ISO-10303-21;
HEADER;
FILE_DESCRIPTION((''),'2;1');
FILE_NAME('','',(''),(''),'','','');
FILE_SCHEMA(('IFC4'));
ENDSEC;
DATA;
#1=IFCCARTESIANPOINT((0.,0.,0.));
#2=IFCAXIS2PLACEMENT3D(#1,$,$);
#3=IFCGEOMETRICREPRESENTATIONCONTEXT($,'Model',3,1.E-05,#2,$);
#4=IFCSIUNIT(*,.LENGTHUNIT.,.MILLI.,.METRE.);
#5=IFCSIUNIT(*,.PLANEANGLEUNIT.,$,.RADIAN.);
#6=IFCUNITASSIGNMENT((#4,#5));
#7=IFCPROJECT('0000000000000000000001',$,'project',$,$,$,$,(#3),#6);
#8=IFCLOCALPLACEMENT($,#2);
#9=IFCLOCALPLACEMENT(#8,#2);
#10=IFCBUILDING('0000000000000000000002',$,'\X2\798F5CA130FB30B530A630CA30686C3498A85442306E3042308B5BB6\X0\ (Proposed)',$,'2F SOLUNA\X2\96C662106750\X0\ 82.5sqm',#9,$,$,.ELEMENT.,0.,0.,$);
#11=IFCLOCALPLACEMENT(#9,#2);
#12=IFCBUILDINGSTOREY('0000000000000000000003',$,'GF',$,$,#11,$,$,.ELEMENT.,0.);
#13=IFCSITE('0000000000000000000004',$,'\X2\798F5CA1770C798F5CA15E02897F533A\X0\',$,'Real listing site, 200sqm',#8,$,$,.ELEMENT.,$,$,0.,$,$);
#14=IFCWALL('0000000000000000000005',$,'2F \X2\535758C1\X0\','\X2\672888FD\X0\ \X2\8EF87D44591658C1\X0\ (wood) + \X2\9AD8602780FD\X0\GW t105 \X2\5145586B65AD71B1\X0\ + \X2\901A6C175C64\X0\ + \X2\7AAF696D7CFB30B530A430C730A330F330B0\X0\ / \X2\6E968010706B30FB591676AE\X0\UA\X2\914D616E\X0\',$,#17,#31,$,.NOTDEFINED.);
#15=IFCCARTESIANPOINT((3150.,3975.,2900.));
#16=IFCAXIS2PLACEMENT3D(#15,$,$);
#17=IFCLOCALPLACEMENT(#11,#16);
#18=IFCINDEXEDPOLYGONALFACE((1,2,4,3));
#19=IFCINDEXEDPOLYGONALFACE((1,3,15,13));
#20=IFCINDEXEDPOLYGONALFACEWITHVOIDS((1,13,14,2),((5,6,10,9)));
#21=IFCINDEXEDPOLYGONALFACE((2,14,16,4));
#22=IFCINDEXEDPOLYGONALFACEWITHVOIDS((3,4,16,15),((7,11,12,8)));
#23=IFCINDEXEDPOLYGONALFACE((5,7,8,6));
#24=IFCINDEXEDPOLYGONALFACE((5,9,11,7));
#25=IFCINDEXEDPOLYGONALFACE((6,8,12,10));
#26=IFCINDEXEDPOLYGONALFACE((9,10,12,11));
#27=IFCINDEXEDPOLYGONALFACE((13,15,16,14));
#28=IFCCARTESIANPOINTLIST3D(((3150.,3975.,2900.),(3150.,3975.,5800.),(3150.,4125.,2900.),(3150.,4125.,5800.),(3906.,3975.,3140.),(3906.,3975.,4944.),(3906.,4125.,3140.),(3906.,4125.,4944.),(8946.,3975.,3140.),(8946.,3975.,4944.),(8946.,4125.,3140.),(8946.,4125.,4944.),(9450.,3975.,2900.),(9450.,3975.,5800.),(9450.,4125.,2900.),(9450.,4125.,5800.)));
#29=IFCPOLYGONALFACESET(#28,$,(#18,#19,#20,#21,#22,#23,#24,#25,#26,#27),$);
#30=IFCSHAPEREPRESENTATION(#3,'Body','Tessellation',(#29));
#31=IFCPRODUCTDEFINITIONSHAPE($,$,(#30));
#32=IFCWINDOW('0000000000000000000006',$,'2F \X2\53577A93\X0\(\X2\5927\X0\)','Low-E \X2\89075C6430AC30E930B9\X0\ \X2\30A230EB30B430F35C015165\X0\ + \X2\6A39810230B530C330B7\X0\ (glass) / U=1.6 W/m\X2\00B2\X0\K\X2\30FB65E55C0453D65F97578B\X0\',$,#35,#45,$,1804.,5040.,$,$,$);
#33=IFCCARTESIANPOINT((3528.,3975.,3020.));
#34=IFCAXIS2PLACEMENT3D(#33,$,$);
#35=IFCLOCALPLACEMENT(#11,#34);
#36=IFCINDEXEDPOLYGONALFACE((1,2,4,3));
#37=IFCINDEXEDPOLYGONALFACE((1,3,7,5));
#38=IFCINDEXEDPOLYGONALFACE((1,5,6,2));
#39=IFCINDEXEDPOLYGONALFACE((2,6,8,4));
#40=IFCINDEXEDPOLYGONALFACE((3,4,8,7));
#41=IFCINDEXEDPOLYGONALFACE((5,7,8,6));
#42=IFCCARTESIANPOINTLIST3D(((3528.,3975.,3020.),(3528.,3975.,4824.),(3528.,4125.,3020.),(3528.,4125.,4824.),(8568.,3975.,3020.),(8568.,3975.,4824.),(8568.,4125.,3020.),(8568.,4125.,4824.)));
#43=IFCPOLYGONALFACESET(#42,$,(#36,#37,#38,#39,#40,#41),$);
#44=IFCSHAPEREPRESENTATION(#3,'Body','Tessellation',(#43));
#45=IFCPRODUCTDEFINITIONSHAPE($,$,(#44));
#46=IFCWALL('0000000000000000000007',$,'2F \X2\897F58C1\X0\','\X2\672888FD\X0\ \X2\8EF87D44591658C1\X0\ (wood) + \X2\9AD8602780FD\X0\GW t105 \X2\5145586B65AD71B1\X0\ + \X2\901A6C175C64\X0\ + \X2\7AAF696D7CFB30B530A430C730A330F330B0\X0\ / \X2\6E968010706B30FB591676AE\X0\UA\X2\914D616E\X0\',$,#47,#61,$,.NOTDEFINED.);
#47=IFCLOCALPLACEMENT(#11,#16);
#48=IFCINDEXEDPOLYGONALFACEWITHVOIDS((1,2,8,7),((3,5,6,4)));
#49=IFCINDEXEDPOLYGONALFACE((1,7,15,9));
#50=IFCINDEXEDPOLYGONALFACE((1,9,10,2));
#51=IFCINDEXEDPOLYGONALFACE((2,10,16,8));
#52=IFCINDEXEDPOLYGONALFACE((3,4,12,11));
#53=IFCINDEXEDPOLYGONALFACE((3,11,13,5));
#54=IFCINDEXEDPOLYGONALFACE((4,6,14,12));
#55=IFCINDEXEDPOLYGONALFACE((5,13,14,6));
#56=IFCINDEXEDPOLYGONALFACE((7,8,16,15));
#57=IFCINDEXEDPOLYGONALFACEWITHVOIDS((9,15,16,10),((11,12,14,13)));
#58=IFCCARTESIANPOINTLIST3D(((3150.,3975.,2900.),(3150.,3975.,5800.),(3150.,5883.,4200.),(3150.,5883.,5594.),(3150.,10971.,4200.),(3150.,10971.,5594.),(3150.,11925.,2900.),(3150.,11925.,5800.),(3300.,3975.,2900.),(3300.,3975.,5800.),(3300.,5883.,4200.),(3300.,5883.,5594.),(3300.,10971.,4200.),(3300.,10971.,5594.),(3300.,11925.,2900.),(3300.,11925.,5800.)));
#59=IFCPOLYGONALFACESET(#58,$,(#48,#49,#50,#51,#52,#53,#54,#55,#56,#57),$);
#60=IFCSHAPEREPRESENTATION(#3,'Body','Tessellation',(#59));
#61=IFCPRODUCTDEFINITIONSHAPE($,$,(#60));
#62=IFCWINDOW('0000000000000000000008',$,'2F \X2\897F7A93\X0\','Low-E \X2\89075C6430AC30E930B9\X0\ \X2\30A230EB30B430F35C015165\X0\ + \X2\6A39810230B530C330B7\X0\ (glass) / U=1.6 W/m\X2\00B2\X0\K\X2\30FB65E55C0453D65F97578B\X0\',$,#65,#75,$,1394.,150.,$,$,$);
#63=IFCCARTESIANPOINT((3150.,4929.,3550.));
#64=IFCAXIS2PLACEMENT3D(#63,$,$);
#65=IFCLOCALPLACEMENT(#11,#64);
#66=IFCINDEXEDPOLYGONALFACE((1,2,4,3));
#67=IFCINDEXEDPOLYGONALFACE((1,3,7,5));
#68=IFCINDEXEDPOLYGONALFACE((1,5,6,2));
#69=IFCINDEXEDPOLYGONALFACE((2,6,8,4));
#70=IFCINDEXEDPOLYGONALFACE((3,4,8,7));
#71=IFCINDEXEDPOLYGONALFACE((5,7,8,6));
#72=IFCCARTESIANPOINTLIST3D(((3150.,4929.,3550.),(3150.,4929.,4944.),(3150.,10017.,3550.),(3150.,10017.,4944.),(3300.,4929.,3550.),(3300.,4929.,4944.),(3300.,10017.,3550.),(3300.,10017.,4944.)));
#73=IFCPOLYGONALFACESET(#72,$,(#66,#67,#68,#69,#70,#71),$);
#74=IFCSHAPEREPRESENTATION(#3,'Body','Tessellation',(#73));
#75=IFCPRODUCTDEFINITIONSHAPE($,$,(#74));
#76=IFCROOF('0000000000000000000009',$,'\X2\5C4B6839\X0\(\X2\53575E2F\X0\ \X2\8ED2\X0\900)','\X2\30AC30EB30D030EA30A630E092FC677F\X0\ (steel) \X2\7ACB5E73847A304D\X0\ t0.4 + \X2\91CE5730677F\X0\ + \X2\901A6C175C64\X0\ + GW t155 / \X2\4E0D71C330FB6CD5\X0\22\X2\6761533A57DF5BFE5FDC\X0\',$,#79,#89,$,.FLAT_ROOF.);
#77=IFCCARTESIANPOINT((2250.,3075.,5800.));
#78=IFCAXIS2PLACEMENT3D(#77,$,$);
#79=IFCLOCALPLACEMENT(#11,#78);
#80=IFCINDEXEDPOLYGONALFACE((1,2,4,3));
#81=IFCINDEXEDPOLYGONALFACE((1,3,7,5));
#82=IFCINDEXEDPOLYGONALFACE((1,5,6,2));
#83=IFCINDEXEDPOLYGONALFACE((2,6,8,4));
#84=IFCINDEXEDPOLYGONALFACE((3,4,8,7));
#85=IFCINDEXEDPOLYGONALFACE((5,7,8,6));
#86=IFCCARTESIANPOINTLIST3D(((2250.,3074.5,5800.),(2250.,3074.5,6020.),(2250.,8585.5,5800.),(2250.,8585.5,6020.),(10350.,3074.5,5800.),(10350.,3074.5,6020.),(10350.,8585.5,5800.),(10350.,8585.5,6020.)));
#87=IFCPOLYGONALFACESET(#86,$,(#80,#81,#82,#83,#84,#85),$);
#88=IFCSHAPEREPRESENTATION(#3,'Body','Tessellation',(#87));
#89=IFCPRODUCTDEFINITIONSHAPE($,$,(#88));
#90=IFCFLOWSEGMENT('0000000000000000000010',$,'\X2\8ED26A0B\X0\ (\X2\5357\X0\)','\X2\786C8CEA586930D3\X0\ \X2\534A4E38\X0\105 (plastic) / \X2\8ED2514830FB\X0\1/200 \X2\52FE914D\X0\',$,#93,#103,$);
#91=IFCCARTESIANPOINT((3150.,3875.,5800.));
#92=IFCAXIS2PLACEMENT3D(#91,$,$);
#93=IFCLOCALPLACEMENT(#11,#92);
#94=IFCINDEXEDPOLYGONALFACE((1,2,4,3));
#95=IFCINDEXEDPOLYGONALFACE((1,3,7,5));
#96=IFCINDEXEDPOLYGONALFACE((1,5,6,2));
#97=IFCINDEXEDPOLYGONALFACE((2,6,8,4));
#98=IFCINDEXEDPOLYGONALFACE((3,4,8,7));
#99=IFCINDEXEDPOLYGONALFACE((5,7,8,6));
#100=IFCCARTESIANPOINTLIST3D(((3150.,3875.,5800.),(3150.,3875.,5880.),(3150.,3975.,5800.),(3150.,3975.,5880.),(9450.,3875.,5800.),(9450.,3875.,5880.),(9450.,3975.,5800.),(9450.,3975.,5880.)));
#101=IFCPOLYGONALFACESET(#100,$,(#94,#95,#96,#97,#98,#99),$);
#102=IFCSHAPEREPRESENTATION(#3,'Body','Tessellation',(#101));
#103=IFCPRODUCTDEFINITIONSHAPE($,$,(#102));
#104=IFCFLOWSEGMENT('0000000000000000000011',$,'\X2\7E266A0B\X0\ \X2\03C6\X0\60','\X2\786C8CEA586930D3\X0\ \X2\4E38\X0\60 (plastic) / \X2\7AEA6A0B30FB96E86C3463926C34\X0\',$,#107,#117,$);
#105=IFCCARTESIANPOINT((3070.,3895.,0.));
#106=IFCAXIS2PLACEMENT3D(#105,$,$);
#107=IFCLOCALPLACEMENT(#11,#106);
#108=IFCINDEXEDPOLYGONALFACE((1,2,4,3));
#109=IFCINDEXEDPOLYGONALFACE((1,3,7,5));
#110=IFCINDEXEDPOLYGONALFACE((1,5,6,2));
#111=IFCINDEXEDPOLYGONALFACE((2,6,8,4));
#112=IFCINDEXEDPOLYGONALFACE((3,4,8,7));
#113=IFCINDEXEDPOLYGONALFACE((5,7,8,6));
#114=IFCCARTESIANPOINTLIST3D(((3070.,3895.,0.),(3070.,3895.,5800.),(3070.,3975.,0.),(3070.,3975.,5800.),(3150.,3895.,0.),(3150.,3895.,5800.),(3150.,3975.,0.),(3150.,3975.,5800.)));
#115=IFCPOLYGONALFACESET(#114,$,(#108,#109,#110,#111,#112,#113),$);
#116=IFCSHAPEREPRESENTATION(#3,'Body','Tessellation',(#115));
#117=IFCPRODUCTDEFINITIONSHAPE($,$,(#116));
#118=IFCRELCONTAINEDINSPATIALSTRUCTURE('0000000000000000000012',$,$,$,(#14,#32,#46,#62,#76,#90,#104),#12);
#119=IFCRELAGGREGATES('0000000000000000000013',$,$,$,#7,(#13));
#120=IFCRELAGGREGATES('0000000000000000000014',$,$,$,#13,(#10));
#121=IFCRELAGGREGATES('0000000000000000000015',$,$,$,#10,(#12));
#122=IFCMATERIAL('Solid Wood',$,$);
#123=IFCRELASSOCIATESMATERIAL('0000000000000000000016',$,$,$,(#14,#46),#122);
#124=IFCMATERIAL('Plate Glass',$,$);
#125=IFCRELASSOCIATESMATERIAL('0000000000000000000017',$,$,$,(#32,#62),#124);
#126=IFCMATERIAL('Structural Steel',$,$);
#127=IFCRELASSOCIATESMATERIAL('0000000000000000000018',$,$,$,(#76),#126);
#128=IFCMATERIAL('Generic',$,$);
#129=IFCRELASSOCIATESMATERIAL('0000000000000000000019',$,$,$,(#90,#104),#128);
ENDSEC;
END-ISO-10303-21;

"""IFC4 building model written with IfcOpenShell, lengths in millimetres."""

from ifc_helpers import new_model, si_unit, frame, frame_2d, origin, place, context, project, spatial, rectangle, extrude, material, element, fill, save


model = new_model("IFC4")

# Units and contexts
model_context = context("Model", 3, precision=1e-05, world=origin())
ifc_project = project(units=[si_unit("LENGTHUNIT", "METRE", prefix="MILLI"), si_unit("PLANEANGLEUNIT", "RADIAN")], contexts=[model_context])

# Site, building, storey
site_placement = place(None, origin())
site = spatial("IfcSite", under=ifc_project, at=site_placement, Name="福岡県福岡市西区", ObjectType="Real listing site, 200sqm", CompositionType="ELEMENT", RefElevation=0.0)
building_placement = place(site_placement, origin())
building = spatial("IfcBuilding", under=site, at=building_placement, Name="福岡・サウナと水風呂のある家 (Proposed)", ObjectType="2F SOLUNA集成材 82.5sqm", CompositionType="ELEMENT", ElevationOfRefHeight=0.0, ElevationOfTerrain=0.0)
storey_placement = place(building_placement, origin())
storey = spatial("IfcBuildingStorey", under=building, at=storey_placement, Name="GF", CompositionType="ELEMENT", Elevation=0.0)

# Shared definitions
ifc_material_1 = material(Name="Solid Wood")

# Shared definitions
ifc_material_2 = material(Name="Plate Glass")

# Walls, openings, windows
wall_1_placement = place(storey_placement, frame((3150.0, 3975.0, 2900.0)))
wall_1 = element("IfcWall", 1, at=wall_1_placement, inside=storey, material=ifc_material_1, Name="2F 南壁", Description="木製 軸組外壁 (wood) + 高性能GW t105 充填断熱 + 通気層 + 窯業系サイディング / 準耐火・外皮UA配慮", PredefinedType="NOTDEFINED", context=model_context, shape_type="SweptSolid", body=[
    extrude(rectangle(XDim=6300.0, YDim=150.0, at=frame_2d((3150.0, 75.0))), frame((3150.0, 3975.0, 2900.0)), (0.0, 0.0, 1.0), 2900.0),
])
opening_1_placement = place(storey_placement, frame((3528.0, 3975.0, 3020.0)))
opening_1 = element("IfcOpeningElement", 2, at=opening_1_placement, cuts=wall_1, PredefinedType="NOTDEFINED", context=model_context, shape_type="SweptSolid", body=[
    extrude(rectangle(XDim=5040.0, YDim=150.0, at=frame_2d((2520.0, 75.0))), frame((3528.0, 3975.0, 3020.0)), (0.0, 0.0, 1.0), 1804.0),
])
window_1_placement = place(storey_placement, frame((3528.0, 3975.0, 3020.0)))
window_1 = element("IfcWindow", 3, at=window_1_placement, inside=storey, material=ifc_material_2, Name="2F 南窓(大)", Description="Low-E 複層ガラス アルゴン封入 + 樹脂サッシ (glass) / U=1.6 W/m²K・日射取得型", OverallHeight=1804.0, OverallWidth=5040.0, context=model_context, shape_type="SweptSolid", body=[
    extrude(rectangle(XDim=5040.0, YDim=150.0, at=frame_2d((2520.0, 75.0))), frame((3528.0, 3975.0, 3020.0)), (0.0, 0.0, 1.0), 1804.0),
])
fill(opening_1, window_1)
wall_2_placement = place(storey_placement, frame((3150.0, 3975.0, 2900.0)))
wall_2 = element("IfcWall", 4, at=wall_2_placement, inside=storey, material=ifc_material_1, Name="2F 西壁", Description="木製 軸組外壁 (wood) + 高性能GW t105 充填断熱 + 通気層 + 窯業系サイディング / 準耐火・外皮UA配慮", PredefinedType="NOTDEFINED", context=model_context, shape_type="SweptSolid", body=[
    extrude(rectangle(XDim=150.0, YDim=7950.0, at=frame_2d((75.0, 3975.0))), frame((3150.0, 3975.0, 2900.0)), (0.0, 0.0, 1.0), 2900.0),
])
opening_2_placement = place(storey_placement, frame((3150.0, 4929.0, 3550.0)))
opening_2 = element("IfcOpeningElement", 5, at=opening_2_placement, cuts=wall_2, PredefinedType="NOTDEFINED", context=model_context, shape_type="SweptSolid", body=[
    extrude(rectangle(XDim=150.0, YDim=5088.0, at=frame_2d((75.0, 2544.0))), frame((3150.0, 4929.0, 3550.0)), (0.0, 0.0, 1.0), 1394.0),
])
window_2_placement = place(storey_placement, frame((3150.0, 4929.0, 3550.0)))
window_2 = element("IfcWindow", 6, at=window_2_placement, inside=storey, material=ifc_material_2, Name="2F 西窓", Description="Low-E 複層ガラス アルゴン封入 + 樹脂サッシ (glass) / U=1.6 W/m²K・日射取得型", OverallHeight=1394.0, OverallWidth=150.0, context=model_context, shape_type="SweptSolid", body=[
    extrude(rectangle(XDim=150.0, YDim=5088.0, at=frame_2d((75.0, 2544.0))), frame((3150.0, 4929.0, 3550.0)), (0.0, 0.0, 1.0), 1394.0),
])
fill(opening_2, window_2)

# Roof
ifc_material_3 = material(Name="Structural Steel")
for number, where, name in (
    (7, (2250.0, 3075.0, 5800.0), "屋根(南帯 軒900)"),
):
    element("IfcRoof", number, at=place(storey_placement, frame(where)), inside=storey, material=ifc_material_3, Name=name, Description="ガルバリウム鋼板 (steel) 立平葺き t0.4 + 野地板 + 通気層 + GW t155 / 不燃・法22条区域対応", PredefinedType="FLAT_ROOF", context=model_context, shape_type="SweptSolid", body=[
        extrude(rectangle(XDim=8100.0, YDim=5511.0, at=frame_2d((4050.0, 2755.0))), frame((2250.0, 3075.0, 5800.0)), (0.0, 0.0, 1.0), 220.0),
    ])

# Flow segments
ifc_material_4 = material(Name="Generic")
flow_segment_1_placement = place(storey_placement, frame((3150.0, 3875.0, 5800.0)))
element("IfcFlowSegment", 8, at=flow_segment_1_placement, inside=storey, material=ifc_material_4, Name="軒樋 (南)", Description="硬質塩ビ 半丸105 (plastic) / 軒先・1/200 勾配", context=model_context, shape_type="SweptSolid", body=[
    extrude(rectangle(XDim=6300.0, YDim=100.0, at=frame_2d((3150.0, 50.0))), frame((3150.0, 3875.0, 5800.0)), (0.0, 0.0, 1.0), 80.0),
])
flow_segment_2_placement = place(storey_placement, frame((3070.0, 3895.0, 0.0)))
element("IfcFlowSegment", 9, at=flow_segment_2_placement, inside=storey, material=ifc_material_4, Name="縦樋 φ60", Description="硬質塩ビ 丸60 (plastic) / 竪樋・雨水排水", context=model_context, shape_type="SweptSolid", body=[
    extrude(rectangle(XDim=80.0, YDim=80.0, at=frame_2d((40.0, 40.0))), frame((3070.0, 3895.0, 0.0)), (0.0, 0.0, 1.0), 5800.0),
])

save(model, "model.ifc")
